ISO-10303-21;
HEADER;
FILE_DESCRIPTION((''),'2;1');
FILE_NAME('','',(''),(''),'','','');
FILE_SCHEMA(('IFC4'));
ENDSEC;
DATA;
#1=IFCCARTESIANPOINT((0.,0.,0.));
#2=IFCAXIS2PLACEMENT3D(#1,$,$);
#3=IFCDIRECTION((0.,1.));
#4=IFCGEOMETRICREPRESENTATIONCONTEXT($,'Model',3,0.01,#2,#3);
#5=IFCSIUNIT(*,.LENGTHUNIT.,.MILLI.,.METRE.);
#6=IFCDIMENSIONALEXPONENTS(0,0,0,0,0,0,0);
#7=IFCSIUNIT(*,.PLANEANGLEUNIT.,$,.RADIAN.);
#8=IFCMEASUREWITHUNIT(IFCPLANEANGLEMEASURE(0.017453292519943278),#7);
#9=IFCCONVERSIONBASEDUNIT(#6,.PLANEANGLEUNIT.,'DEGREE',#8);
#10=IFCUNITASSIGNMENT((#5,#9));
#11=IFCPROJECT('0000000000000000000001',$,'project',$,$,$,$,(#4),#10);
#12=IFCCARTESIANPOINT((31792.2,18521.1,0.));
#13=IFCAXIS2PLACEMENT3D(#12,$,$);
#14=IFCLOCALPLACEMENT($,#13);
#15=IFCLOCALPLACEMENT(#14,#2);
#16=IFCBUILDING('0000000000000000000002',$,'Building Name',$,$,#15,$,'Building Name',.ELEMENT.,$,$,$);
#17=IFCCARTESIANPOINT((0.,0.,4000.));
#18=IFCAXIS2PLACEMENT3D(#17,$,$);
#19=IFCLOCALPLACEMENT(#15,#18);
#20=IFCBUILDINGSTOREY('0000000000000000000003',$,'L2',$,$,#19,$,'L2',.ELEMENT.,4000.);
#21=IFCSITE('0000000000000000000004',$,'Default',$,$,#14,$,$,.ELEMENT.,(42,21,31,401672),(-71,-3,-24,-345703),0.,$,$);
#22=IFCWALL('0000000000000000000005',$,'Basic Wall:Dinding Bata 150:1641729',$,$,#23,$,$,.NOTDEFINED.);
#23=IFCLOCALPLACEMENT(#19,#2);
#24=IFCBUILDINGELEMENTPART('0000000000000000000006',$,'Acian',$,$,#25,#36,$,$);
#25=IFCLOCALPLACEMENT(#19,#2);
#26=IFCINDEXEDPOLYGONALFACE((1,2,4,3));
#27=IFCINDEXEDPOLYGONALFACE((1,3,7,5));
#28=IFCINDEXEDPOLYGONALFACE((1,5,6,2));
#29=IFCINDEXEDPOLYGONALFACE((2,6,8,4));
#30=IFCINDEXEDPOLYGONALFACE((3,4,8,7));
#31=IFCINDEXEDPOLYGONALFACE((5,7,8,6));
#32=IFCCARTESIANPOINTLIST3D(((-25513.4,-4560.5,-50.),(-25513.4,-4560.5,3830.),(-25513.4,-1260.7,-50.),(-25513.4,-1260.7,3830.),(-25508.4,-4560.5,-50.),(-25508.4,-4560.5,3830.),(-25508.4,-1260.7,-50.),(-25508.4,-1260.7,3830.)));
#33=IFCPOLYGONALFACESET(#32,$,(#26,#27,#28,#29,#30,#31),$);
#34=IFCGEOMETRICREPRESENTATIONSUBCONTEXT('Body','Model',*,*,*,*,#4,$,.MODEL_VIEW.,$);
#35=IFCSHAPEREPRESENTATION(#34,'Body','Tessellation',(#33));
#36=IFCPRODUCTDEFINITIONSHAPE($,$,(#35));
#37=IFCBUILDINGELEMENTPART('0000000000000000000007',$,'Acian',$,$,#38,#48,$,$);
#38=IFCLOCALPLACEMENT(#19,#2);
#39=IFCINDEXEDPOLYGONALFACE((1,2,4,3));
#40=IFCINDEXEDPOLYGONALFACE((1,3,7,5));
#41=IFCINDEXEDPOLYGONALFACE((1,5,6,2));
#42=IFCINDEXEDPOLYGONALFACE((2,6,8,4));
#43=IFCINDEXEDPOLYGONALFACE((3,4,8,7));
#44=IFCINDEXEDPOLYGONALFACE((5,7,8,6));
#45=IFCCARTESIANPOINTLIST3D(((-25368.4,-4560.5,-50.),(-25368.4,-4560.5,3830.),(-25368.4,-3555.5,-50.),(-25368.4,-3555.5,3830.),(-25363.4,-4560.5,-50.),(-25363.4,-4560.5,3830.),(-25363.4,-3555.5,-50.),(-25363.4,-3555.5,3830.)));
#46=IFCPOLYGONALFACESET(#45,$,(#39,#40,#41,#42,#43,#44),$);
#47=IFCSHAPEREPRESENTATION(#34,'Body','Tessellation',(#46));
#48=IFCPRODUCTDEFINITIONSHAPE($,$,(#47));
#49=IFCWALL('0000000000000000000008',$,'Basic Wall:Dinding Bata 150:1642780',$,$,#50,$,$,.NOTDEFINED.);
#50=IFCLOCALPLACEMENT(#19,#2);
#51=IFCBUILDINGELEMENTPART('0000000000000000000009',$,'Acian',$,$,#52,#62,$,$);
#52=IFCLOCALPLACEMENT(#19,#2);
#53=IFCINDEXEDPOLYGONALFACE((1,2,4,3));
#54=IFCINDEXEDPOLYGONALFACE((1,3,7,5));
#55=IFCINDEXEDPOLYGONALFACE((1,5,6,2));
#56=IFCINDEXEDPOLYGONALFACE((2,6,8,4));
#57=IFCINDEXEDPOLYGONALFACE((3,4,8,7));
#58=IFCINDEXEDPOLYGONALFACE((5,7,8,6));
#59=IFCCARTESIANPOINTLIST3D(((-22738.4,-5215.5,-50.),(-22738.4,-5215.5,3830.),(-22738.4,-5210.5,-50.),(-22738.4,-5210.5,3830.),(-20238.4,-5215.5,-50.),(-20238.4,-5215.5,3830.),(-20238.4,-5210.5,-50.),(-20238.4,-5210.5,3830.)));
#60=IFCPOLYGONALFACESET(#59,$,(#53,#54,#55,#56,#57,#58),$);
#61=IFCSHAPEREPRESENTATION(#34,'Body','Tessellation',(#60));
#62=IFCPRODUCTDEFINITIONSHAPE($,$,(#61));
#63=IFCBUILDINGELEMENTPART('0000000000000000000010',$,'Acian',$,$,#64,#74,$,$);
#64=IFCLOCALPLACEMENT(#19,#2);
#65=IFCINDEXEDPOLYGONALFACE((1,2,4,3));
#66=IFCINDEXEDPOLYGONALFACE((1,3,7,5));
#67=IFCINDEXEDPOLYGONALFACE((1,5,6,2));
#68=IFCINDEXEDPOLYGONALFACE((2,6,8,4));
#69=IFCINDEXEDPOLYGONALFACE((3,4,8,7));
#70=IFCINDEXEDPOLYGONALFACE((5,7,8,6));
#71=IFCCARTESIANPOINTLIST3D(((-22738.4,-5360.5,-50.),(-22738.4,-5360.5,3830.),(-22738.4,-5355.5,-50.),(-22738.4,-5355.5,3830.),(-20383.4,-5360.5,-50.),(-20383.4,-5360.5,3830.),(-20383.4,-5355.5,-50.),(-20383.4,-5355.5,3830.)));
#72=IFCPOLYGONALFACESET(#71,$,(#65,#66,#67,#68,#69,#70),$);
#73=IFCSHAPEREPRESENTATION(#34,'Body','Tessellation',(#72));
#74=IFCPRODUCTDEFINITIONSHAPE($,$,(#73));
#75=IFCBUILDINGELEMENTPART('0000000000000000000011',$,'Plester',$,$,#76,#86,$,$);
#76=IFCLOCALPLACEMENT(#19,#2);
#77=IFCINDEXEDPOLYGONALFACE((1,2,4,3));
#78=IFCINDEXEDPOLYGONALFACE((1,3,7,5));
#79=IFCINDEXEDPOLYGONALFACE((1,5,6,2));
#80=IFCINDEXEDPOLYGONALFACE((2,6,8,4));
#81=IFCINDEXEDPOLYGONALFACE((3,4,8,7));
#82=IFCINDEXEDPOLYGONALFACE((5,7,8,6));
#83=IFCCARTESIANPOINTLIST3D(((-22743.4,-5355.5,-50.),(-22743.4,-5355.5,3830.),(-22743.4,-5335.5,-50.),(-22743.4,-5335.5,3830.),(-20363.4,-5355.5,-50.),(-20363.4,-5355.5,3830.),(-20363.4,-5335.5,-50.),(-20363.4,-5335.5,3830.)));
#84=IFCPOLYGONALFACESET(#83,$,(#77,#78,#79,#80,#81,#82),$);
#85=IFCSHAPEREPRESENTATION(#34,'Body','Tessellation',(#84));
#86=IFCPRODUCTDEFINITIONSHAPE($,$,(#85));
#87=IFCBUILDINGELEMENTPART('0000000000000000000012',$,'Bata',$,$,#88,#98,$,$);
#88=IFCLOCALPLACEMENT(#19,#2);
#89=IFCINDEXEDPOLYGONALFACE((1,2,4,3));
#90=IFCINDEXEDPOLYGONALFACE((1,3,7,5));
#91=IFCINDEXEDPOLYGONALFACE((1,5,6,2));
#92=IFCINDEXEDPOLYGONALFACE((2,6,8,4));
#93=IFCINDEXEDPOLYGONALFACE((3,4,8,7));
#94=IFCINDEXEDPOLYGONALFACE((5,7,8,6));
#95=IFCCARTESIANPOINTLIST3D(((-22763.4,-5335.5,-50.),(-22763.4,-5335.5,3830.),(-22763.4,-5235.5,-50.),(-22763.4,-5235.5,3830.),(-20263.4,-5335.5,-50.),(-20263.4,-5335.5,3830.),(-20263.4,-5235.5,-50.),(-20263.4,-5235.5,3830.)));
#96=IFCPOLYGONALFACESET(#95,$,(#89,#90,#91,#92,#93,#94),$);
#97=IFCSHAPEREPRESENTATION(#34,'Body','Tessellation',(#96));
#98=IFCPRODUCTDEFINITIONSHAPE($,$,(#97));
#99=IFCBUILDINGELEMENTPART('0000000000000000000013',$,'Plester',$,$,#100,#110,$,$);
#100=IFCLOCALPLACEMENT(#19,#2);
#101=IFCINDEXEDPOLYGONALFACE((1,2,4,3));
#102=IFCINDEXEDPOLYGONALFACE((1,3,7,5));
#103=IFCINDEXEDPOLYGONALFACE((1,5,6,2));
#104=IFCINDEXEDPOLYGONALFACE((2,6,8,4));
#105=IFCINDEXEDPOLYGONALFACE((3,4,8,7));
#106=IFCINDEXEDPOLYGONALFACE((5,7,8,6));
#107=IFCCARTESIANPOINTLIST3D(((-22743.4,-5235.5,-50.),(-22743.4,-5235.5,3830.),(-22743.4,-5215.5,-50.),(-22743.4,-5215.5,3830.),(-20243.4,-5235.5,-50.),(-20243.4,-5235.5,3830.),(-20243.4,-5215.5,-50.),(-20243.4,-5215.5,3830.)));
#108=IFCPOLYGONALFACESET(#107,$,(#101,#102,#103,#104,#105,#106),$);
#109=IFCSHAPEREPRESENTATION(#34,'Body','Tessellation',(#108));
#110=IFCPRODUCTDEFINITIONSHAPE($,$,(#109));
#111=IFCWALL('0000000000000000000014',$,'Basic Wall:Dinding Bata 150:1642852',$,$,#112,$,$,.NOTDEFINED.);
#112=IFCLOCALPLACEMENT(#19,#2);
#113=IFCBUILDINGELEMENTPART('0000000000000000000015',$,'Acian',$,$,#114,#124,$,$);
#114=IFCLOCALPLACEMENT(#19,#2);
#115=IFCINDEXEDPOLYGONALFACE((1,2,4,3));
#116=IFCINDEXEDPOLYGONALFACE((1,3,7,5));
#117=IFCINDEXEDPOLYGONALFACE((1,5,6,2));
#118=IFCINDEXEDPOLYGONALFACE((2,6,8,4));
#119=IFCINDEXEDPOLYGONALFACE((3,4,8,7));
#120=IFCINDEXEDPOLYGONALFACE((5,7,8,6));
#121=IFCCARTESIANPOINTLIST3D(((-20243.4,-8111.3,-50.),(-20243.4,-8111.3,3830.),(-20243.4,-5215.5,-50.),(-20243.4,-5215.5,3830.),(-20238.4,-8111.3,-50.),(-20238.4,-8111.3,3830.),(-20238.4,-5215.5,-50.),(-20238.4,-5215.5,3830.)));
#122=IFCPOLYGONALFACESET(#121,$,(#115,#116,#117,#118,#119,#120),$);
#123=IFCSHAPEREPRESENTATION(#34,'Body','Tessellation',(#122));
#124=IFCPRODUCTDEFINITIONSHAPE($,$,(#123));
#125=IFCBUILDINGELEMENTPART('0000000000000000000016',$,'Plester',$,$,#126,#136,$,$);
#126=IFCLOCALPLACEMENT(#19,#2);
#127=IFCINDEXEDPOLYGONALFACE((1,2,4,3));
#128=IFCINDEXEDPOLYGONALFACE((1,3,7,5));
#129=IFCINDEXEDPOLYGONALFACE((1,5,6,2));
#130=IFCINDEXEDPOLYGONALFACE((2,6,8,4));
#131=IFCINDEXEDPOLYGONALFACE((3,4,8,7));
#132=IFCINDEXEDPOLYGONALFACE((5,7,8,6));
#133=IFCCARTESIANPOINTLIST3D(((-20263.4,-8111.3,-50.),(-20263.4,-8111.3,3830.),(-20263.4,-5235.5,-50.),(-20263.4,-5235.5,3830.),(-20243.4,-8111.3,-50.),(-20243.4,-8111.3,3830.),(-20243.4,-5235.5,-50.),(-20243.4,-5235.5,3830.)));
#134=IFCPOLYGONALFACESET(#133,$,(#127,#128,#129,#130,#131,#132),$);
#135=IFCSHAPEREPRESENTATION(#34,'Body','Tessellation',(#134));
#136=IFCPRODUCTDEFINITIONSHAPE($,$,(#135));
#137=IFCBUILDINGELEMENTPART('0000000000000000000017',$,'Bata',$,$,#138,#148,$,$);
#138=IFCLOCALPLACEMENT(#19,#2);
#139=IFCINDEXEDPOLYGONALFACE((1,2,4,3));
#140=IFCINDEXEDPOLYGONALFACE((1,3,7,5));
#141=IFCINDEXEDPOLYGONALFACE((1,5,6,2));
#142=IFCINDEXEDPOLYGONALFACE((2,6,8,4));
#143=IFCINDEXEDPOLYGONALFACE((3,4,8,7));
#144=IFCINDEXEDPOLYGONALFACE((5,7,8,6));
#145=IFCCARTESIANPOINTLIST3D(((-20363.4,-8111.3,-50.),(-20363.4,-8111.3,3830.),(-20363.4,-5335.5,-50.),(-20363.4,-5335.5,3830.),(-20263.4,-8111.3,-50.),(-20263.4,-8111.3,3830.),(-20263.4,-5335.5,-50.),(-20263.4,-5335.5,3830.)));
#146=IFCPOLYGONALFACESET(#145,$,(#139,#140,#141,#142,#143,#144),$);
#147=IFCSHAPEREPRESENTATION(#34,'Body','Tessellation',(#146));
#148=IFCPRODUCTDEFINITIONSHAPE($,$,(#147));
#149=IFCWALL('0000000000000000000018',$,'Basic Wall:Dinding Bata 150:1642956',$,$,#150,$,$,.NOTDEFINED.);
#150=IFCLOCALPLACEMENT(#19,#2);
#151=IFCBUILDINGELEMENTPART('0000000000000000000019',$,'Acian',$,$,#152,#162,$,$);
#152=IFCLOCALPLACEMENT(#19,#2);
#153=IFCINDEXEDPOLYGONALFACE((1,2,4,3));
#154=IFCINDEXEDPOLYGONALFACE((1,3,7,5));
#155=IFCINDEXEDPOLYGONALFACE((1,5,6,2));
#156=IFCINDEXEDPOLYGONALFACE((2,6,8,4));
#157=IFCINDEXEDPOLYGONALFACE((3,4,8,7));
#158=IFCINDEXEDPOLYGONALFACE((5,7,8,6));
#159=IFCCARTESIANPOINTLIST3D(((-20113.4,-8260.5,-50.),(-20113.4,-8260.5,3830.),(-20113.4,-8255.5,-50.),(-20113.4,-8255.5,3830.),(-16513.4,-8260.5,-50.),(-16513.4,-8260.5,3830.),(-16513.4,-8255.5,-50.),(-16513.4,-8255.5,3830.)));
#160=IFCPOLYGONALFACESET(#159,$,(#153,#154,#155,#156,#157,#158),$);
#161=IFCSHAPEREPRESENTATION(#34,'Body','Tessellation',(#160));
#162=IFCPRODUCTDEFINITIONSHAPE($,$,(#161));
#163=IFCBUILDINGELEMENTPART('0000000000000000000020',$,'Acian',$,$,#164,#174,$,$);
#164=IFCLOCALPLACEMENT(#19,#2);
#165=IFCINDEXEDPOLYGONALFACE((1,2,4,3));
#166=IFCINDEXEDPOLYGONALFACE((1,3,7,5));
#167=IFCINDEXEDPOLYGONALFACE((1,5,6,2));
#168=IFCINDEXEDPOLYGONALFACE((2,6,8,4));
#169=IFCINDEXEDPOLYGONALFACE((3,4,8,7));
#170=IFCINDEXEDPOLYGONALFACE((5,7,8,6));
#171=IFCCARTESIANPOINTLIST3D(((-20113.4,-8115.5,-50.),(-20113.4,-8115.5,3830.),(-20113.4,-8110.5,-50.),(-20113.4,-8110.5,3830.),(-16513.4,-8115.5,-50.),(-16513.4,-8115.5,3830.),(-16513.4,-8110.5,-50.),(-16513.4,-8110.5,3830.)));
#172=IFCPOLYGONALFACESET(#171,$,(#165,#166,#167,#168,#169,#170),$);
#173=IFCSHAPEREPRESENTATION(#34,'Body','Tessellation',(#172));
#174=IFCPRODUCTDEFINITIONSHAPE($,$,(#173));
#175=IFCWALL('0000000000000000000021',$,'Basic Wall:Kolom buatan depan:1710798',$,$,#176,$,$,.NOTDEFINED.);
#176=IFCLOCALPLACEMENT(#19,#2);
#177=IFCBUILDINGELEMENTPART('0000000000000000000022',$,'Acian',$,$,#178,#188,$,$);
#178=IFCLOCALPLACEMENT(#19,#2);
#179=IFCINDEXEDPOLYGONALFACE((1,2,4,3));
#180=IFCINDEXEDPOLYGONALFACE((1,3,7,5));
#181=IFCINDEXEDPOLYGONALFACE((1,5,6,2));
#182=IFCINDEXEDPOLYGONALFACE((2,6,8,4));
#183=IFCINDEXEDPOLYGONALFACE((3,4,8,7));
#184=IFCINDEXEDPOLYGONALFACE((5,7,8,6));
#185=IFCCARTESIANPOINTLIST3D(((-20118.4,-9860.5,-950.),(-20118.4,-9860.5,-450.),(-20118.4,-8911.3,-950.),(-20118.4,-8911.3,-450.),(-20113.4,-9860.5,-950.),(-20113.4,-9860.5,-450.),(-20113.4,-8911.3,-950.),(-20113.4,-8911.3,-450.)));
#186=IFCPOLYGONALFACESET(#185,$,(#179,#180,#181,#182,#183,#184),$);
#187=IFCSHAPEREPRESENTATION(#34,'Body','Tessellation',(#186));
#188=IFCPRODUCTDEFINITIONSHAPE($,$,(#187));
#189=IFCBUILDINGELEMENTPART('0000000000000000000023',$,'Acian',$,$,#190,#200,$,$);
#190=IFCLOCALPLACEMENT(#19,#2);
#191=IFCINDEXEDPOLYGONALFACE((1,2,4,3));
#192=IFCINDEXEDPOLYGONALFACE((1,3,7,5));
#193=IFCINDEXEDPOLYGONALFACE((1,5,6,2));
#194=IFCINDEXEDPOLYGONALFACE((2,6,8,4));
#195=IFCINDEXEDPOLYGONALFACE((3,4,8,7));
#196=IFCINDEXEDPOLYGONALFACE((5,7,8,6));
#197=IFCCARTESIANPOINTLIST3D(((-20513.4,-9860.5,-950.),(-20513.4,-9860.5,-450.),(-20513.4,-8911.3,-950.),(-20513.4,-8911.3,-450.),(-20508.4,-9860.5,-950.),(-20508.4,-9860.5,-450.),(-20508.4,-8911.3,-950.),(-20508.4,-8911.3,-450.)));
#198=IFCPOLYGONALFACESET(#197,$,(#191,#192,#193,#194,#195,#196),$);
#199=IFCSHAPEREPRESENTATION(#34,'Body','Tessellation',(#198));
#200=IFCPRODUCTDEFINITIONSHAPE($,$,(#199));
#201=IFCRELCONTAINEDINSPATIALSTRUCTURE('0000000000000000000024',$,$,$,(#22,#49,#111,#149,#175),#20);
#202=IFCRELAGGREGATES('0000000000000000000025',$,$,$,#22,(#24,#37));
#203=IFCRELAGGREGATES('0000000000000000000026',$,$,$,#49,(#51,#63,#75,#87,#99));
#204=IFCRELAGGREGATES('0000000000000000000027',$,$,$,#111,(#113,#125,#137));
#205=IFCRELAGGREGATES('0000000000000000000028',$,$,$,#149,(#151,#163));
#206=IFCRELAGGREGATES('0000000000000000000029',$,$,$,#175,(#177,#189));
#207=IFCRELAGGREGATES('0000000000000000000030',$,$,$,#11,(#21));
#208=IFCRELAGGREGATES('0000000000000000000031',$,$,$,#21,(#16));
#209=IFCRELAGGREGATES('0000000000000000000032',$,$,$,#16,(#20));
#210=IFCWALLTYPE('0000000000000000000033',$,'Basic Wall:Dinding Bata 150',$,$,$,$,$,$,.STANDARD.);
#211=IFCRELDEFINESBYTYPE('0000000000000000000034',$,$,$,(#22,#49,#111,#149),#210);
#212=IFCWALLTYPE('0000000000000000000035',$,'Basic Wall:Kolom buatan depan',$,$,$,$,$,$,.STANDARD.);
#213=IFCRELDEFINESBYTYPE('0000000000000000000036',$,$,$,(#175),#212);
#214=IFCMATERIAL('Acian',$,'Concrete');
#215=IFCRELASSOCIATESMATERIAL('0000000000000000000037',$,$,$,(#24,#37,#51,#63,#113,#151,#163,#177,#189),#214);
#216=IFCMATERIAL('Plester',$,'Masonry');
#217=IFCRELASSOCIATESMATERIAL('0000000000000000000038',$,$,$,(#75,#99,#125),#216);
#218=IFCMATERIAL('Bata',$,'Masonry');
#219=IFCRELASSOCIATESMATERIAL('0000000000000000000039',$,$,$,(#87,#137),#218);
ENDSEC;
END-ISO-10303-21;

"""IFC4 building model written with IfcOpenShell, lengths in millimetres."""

from ifc_helpers import new_model, entity, si_unit, converted_unit, direction, frame, origin, place, context, subcontext, project, spatial, indexed_curve, outline, extrude, material, type_object, element, aggregate, save


model = new_model("IFC4")

# Units and contexts
model_context = context("Model", 3, precision=0.01, world=origin(), true_north=direction((0.0, 1.0)))
body_context = subcontext(model_context, "Body", "Model", "MODEL_VIEW")
ifc_project = project(units=[si_unit("LENGTHUNIT", "METRE", prefix="MILLI"), converted_unit("PLANEANGLEUNIT", "DEGREE", entity("IfcPlaneAngleMeasure", 0.017453292519943278), si_unit("PLANEANGLEUNIT", "RADIAN"), dimensions=[0, 0, 0, 0, 0, 0, 0])], contexts=[model_context])

# Site, building, storey
site_placement = place(None, frame((31792.2, 18521.1, 0.0)))
site = spatial("IfcSite", under=ifc_project, at=site_placement, Name="Default", CompositionType="ELEMENT", RefLatitude=(42, 21, 31, 401672), RefLongitude=(-71, -3, -24, -345703), RefElevation=0.0)
building_placement = place(site_placement, origin())
building = spatial("IfcBuilding", under=site, at=building_placement, Name="Building Name", LongName="Building Name", CompositionType="ELEMENT")
storey_placement = place(building_placement, frame((0.0, 0.0, 4000.0)))
storey = spatial("IfcBuildingStorey", under=building, at=storey_placement, Name="L2", LongName="L2", CompositionType="ELEMENT", Elevation=4000.0)

# Wall, building element parts
wall_type_1 = type_object("IfcWallType", Name="Basic Wall:Dinding Bata 150", PredefinedType="STANDARD")
wall_1_placement = place(storey_placement, frame((-25438.4, -1260.7, -50.0), z_axis=(0.0, 0.0, 1.0), x_axis=(0.0, -1.0, 0.0)))
wall_1 = element("IfcWall", 1, at=wall_1_placement, inside=storey, type_object=wall_type_1, Name="Basic Wall:Dinding Bata 150:1641729", PredefinedType="NOTDEFINED")
ifc_material_1 = material(Name="Acian", Category="Concrete")
building_element_part_1_placement = place(wall_1_placement, origin())
building_element_part_1 = element("IfcBuildingElementPart", 2, at=building_element_part_1_placement, material=ifc_material_1, Name="Acian", context=body_context, shape_type="SweptSolid", body=[
    extrude(outline(indexed_curve([(-1649.9, -2.5), (1649.9, -2.5), (1649.9, 2.5), (-1649.9, 2.5), (-1649.9, -2.5)], self_intersect=False)), frame((1649.9, -72.5, 0.0)), (0.0, 0.0, 1.0), 3880.0),
])
building_element_part_2_placement = place(wall_1_placement, origin())
building_element_part_2 = element("IfcBuildingElementPart", 3, at=building_element_part_2_placement, material=ifc_material_1, Name="Acian", context=body_context, shape_type="SweptSolid", body=[
    extrude(outline(indexed_curve([(-502.5, -2.5), (502.5, -2.5), (502.5, 2.5), (-502.5, 2.5), (-502.5, -2.5)], self_intersect=False)), frame((2797.3, 72.5, 0.0)), (0.0, 0.0, 1.0), 3880.0),
])
aggregate(wall_1, [building_element_part_1, building_element_part_2])

# Walls, building element parts
wall_2_placement = place(storey_placement, frame((-20238.4, -5285.5, -50.0), z_axis=(0.0, 0.0, 1.0), x_axis=(-1.0, 0.0, 0.0)))
wall_2 = element("IfcWall", 4, at=wall_2_placement, inside=storey, type_object=wall_type_1, Name="Basic Wall:Dinding Bata 150:1642780", PredefinedType="NOTDEFINED")
building_element_part_3_placement = place(wall_2_placement, origin())
building_element_part_3 = element("IfcBuildingElementPart", 5, at=building_element_part_3_placement, material=ifc_material_1, Name="Acian", context=body_context, shape_type="SweptSolid", body=[
    extrude(outline(indexed_curve([(-2.5, -1250.0), (2.5, -1250.0), (2.5, 1250.0), (-2.5, 1250.0), (-2.5, -1250.0)], self_intersect=False)), frame((1250.0, -72.5, 0.0), z_axis=(0.0, 0.0, 1.0), x_axis=(0.0, 1.0, 0.0)), (0.0, 0.0, 1.0), 3880.0),
])
building_element_part_4_placement = place(wall_2_placement, origin())
building_element_part_4 = element("IfcBuildingElementPart", 6, at=building_element_part_4_placement, material=ifc_material_1, Name="Acian", context=body_context, shape_type="SweptSolid", body=[
    extrude(outline(indexed_curve([(-2.5, -1177.5), (2.5, -1177.5), (2.5, 1177.5), (-2.5, 1177.5), (-2.5, -1177.5)], self_intersect=False)), frame((1322.5, 72.5, 0.0), z_axis=(0.0, 0.0, 1.0), x_axis=(0.0, 1.0, 0.0)), (0.0, 0.0, 1.0), 3880.0),
])
ifc_material_2 = material(Name="Plester", Category="Masonry")
building_element_part_5_placement = place(wall_2_placement, origin())
building_element_part_5 = element("IfcBuildingElementPart", 7, at=building_element_part_5_placement, material=ifc_material_2, Name="Plester", context=body_context, shape_type="SweptSolid", body=[
    extrude(outline(indexed_curve([(-10.0, -1190.0), (10.0, -1190.0), (10.0, 1190.0), (-10.0, 1190.0), (-10.0, -1190.0)], self_intersect=False)), frame((1315.0, 60.0, 0.0), z_axis=(0.0, 0.0, 1.0), x_axis=(0.0, 1.0, 0.0)), (0.0, 0.0, 1.0), 3880.0),
])
ifc_material_3 = material(Name="Bata", Category="Masonry")
building_element_part_6_placement = place(wall_2_placement, origin())
building_element_part_6 = element("IfcBuildingElementPart", 8, at=building_element_part_6_placement, material=ifc_material_3, Name="Bata", context=body_context, shape_type="SweptSolid", body=[
    extrude(outline(indexed_curve([(-50.0, -1250.0), (50.0, -1250.0), (50.0, 1250.0), (-50.0, 1250.0), (-50.0, -1250.0)], self_intersect=False)), frame((1275.0, 0.0, 0.0), z_axis=(0.0, 0.0, 1.0), x_axis=(0.0, 1.0, 0.0)), (0.0, 0.0, 1.0), 3880.0),
])
building_element_part_7_placement = place(wall_2_placement, origin())
building_element_part_7 = element("IfcBuildingElementPart", 9, at=building_element_part_7_placement, material=ifc_material_2, Name="Plester", context=body_context, shape_type="SweptSolid", body=[
    extrude(outline(indexed_curve([(-10.0, -1250.0), (10.0, -1250.0), (10.0, 1250.0), (-10.0, 1250.0), (-10.0, -1250.0)], self_intersect=False)), frame((1255.0, -60.0, 0.0), z_axis=(0.0, 0.0, 1.0), x_axis=(0.0, 1.0, 0.0)), (0.0, 0.0, 1.0), 3880.0),
])
aggregate(wall_2, [building_element_part_3, building_element_part_4, building_element_part_5, building_element_part_6, building_element_part_7])
wall_3_placement = place(storey_placement, frame((-20313.4, -5360.5, -50.0), z_axis=(0.0, 0.0, 1.0), x_axis=(0.0, -1.0, 0.0)))
wall_3 = element("IfcWall", 10, at=wall_3_placement, inside=storey, type_object=wall_type_1, Name="Basic Wall:Dinding Bata 150:1642852", PredefinedType="NOTDEFINED")
building_element_part_8_placement = place(wall_3_placement, origin())
building_element_part_8 = element("IfcBuildingElementPart", 11, at=building_element_part_8_placement, material=ifc_material_1, Name="Acian", context=body_context, shape_type="SweptSolid", body=[
    extrude(outline(indexed_curve([(-1447.9, -2.5), (1447.9, -2.5), (1447.9, 2.5), (-1447.9, 2.5), (-1447.9, -2.5)], self_intersect=False)), frame((1302.9, 72.5, 0.0)), (0.0, 0.0, 1.0), 3880.0),
])
building_element_part_9_placement = place(wall_3_placement, origin())
building_element_part_9 = element("IfcBuildingElementPart", 12, at=building_element_part_9_placement, material=ifc_material_2, Name="Plester", context=body_context, shape_type="SweptSolid", body=[
    extrude(outline(indexed_curve([(-1437.9, -10.0), (1437.9, -10.0), (1437.9, 10.0), (-1437.9, 10.0), (-1437.9, -10.0)], self_intersect=False)), frame((1312.9, 60.0, 0.0)), (0.0, 0.0, 1.0), 3880.0),
])
building_element_part_10_placement = place(wall_3_placement, origin())
building_element_part_10 = element("IfcBuildingElementPart", 13, at=building_element_part_10_placement, material=ifc_material_3, Name="Bata", context=body_context, shape_type="SweptSolid", body=[
    extrude(outline(indexed_curve([(-1387.9, -50.0), (1387.9, -50.0), (1387.9, 50.0), (-1387.9, 50.0), (-1387.9, -50.0)], self_intersect=False)), frame((1362.9, 0.0, 0.0)), (0.0, 0.0, 1.0), 3880.0),
])
aggregate(wall_3, [building_element_part_8, building_element_part_9, building_element_part_10])
wall_4_placement = place(storey_placement, frame((-20113.4, -8185.5, -50.0)))
wall_4 = element("IfcWall", 14, at=wall_4_placement, inside=storey, type_object=wall_type_1, Name="Basic Wall:Dinding Bata 150:1642956", PredefinedType="NOTDEFINED")
building_element_part_11_placement = place(wall_4_placement, origin())
building_element_part_11 = element("IfcBuildingElementPart", 15, at=building_element_part_11_placement, material=ifc_material_1, Name="Acian", context=body_context, shape_type="SweptSolid", body=[
    extrude(outline(indexed_curve([(-2.5, -1800.0), (2.5, -1800.0), (2.5, 1800.0), (-2.5, 1800.0), (-2.5, -1800.0)], self_intersect=False)), frame((1800.0, -72.5, 0.0), z_axis=(0.0, 0.0, 1.0), x_axis=(0.0, -1.0, 0.0)), (0.0, 0.0, 1.0), 3880.0),
])
building_element_part_12_placement = place(wall_4_placement, origin())
building_element_part_12 = element("IfcBuildingElementPart", 16, at=building_element_part_12_placement, material=ifc_material_1, Name="Acian", context=body_context, shape_type="SweptSolid", body=[
    extrude(outline(indexed_curve([(-2.5, -1800.0), (2.5, -1800.0), (2.5, 1800.0), (-2.5, 1800.0), (-2.5, -1800.0)], self_intersect=False)), frame((1800.0, 72.5, 0.0), z_axis=(0.0, 0.0, 1.0), x_axis=(0.0, -1.0, 0.0)), (0.0, 0.0, 1.0), 3880.0),
])
aggregate(wall_4, [building_element_part_11, building_element_part_12])
wall_type_2 = type_object("IfcWallType", Name="Basic Wall:Kolom buatan depan", PredefinedType="STANDARD")
wall_5_placement = place(storey_placement, frame((-20313.4, -8911.3, -950.0), z_axis=(0.0, 0.0, 1.0), x_axis=(0.0, -1.0, 0.0)))
wall_5 = element("IfcWall", 17, at=wall_5_placement, inside=storey, type_object=wall_type_2, Name="Basic Wall:Kolom buatan depan:1710798", PredefinedType="NOTDEFINED")
building_element_part_13_placement = place(wall_5_placement, origin())
building_element_part_13 = element("IfcBuildingElementPart", 18, at=building_element_part_13_placement, material=ifc_material_1, Name="Acian", context=body_context, shape_type="SweptSolid", body=[
    extrude(outline(indexed_curve([(-474.6, -2.5), (474.6, -2.5), (474.6, 2.5), (-474.6, 2.5), (-474.6, -2.5)], self_intersect=False)), frame((474.6, 197.5, 0.0)), (0.0, 0.0, 1.0), 500.0),
])
building_element_part_14_placement = place(wall_5_placement, origin())
building_element_part_14 = element("IfcBuildingElementPart", 19, at=building_element_part_14_placement, material=ifc_material_1, Name="Acian", context=body_context, shape_type="SweptSolid", body=[
    extrude(outline(indexed_curve([(-474.6, -2.5), (474.6, -2.5), (474.6, 2.5), (-474.6, 2.5), (-474.6, -2.5)], self_intersect=False)), frame((474.6, -197.5, 0.0)), (0.0, 0.0, 1.0), 500.0),
])
aggregate(wall_5, [building_element_part_13, building_element_part_14])

save(model, "model.ifc")
